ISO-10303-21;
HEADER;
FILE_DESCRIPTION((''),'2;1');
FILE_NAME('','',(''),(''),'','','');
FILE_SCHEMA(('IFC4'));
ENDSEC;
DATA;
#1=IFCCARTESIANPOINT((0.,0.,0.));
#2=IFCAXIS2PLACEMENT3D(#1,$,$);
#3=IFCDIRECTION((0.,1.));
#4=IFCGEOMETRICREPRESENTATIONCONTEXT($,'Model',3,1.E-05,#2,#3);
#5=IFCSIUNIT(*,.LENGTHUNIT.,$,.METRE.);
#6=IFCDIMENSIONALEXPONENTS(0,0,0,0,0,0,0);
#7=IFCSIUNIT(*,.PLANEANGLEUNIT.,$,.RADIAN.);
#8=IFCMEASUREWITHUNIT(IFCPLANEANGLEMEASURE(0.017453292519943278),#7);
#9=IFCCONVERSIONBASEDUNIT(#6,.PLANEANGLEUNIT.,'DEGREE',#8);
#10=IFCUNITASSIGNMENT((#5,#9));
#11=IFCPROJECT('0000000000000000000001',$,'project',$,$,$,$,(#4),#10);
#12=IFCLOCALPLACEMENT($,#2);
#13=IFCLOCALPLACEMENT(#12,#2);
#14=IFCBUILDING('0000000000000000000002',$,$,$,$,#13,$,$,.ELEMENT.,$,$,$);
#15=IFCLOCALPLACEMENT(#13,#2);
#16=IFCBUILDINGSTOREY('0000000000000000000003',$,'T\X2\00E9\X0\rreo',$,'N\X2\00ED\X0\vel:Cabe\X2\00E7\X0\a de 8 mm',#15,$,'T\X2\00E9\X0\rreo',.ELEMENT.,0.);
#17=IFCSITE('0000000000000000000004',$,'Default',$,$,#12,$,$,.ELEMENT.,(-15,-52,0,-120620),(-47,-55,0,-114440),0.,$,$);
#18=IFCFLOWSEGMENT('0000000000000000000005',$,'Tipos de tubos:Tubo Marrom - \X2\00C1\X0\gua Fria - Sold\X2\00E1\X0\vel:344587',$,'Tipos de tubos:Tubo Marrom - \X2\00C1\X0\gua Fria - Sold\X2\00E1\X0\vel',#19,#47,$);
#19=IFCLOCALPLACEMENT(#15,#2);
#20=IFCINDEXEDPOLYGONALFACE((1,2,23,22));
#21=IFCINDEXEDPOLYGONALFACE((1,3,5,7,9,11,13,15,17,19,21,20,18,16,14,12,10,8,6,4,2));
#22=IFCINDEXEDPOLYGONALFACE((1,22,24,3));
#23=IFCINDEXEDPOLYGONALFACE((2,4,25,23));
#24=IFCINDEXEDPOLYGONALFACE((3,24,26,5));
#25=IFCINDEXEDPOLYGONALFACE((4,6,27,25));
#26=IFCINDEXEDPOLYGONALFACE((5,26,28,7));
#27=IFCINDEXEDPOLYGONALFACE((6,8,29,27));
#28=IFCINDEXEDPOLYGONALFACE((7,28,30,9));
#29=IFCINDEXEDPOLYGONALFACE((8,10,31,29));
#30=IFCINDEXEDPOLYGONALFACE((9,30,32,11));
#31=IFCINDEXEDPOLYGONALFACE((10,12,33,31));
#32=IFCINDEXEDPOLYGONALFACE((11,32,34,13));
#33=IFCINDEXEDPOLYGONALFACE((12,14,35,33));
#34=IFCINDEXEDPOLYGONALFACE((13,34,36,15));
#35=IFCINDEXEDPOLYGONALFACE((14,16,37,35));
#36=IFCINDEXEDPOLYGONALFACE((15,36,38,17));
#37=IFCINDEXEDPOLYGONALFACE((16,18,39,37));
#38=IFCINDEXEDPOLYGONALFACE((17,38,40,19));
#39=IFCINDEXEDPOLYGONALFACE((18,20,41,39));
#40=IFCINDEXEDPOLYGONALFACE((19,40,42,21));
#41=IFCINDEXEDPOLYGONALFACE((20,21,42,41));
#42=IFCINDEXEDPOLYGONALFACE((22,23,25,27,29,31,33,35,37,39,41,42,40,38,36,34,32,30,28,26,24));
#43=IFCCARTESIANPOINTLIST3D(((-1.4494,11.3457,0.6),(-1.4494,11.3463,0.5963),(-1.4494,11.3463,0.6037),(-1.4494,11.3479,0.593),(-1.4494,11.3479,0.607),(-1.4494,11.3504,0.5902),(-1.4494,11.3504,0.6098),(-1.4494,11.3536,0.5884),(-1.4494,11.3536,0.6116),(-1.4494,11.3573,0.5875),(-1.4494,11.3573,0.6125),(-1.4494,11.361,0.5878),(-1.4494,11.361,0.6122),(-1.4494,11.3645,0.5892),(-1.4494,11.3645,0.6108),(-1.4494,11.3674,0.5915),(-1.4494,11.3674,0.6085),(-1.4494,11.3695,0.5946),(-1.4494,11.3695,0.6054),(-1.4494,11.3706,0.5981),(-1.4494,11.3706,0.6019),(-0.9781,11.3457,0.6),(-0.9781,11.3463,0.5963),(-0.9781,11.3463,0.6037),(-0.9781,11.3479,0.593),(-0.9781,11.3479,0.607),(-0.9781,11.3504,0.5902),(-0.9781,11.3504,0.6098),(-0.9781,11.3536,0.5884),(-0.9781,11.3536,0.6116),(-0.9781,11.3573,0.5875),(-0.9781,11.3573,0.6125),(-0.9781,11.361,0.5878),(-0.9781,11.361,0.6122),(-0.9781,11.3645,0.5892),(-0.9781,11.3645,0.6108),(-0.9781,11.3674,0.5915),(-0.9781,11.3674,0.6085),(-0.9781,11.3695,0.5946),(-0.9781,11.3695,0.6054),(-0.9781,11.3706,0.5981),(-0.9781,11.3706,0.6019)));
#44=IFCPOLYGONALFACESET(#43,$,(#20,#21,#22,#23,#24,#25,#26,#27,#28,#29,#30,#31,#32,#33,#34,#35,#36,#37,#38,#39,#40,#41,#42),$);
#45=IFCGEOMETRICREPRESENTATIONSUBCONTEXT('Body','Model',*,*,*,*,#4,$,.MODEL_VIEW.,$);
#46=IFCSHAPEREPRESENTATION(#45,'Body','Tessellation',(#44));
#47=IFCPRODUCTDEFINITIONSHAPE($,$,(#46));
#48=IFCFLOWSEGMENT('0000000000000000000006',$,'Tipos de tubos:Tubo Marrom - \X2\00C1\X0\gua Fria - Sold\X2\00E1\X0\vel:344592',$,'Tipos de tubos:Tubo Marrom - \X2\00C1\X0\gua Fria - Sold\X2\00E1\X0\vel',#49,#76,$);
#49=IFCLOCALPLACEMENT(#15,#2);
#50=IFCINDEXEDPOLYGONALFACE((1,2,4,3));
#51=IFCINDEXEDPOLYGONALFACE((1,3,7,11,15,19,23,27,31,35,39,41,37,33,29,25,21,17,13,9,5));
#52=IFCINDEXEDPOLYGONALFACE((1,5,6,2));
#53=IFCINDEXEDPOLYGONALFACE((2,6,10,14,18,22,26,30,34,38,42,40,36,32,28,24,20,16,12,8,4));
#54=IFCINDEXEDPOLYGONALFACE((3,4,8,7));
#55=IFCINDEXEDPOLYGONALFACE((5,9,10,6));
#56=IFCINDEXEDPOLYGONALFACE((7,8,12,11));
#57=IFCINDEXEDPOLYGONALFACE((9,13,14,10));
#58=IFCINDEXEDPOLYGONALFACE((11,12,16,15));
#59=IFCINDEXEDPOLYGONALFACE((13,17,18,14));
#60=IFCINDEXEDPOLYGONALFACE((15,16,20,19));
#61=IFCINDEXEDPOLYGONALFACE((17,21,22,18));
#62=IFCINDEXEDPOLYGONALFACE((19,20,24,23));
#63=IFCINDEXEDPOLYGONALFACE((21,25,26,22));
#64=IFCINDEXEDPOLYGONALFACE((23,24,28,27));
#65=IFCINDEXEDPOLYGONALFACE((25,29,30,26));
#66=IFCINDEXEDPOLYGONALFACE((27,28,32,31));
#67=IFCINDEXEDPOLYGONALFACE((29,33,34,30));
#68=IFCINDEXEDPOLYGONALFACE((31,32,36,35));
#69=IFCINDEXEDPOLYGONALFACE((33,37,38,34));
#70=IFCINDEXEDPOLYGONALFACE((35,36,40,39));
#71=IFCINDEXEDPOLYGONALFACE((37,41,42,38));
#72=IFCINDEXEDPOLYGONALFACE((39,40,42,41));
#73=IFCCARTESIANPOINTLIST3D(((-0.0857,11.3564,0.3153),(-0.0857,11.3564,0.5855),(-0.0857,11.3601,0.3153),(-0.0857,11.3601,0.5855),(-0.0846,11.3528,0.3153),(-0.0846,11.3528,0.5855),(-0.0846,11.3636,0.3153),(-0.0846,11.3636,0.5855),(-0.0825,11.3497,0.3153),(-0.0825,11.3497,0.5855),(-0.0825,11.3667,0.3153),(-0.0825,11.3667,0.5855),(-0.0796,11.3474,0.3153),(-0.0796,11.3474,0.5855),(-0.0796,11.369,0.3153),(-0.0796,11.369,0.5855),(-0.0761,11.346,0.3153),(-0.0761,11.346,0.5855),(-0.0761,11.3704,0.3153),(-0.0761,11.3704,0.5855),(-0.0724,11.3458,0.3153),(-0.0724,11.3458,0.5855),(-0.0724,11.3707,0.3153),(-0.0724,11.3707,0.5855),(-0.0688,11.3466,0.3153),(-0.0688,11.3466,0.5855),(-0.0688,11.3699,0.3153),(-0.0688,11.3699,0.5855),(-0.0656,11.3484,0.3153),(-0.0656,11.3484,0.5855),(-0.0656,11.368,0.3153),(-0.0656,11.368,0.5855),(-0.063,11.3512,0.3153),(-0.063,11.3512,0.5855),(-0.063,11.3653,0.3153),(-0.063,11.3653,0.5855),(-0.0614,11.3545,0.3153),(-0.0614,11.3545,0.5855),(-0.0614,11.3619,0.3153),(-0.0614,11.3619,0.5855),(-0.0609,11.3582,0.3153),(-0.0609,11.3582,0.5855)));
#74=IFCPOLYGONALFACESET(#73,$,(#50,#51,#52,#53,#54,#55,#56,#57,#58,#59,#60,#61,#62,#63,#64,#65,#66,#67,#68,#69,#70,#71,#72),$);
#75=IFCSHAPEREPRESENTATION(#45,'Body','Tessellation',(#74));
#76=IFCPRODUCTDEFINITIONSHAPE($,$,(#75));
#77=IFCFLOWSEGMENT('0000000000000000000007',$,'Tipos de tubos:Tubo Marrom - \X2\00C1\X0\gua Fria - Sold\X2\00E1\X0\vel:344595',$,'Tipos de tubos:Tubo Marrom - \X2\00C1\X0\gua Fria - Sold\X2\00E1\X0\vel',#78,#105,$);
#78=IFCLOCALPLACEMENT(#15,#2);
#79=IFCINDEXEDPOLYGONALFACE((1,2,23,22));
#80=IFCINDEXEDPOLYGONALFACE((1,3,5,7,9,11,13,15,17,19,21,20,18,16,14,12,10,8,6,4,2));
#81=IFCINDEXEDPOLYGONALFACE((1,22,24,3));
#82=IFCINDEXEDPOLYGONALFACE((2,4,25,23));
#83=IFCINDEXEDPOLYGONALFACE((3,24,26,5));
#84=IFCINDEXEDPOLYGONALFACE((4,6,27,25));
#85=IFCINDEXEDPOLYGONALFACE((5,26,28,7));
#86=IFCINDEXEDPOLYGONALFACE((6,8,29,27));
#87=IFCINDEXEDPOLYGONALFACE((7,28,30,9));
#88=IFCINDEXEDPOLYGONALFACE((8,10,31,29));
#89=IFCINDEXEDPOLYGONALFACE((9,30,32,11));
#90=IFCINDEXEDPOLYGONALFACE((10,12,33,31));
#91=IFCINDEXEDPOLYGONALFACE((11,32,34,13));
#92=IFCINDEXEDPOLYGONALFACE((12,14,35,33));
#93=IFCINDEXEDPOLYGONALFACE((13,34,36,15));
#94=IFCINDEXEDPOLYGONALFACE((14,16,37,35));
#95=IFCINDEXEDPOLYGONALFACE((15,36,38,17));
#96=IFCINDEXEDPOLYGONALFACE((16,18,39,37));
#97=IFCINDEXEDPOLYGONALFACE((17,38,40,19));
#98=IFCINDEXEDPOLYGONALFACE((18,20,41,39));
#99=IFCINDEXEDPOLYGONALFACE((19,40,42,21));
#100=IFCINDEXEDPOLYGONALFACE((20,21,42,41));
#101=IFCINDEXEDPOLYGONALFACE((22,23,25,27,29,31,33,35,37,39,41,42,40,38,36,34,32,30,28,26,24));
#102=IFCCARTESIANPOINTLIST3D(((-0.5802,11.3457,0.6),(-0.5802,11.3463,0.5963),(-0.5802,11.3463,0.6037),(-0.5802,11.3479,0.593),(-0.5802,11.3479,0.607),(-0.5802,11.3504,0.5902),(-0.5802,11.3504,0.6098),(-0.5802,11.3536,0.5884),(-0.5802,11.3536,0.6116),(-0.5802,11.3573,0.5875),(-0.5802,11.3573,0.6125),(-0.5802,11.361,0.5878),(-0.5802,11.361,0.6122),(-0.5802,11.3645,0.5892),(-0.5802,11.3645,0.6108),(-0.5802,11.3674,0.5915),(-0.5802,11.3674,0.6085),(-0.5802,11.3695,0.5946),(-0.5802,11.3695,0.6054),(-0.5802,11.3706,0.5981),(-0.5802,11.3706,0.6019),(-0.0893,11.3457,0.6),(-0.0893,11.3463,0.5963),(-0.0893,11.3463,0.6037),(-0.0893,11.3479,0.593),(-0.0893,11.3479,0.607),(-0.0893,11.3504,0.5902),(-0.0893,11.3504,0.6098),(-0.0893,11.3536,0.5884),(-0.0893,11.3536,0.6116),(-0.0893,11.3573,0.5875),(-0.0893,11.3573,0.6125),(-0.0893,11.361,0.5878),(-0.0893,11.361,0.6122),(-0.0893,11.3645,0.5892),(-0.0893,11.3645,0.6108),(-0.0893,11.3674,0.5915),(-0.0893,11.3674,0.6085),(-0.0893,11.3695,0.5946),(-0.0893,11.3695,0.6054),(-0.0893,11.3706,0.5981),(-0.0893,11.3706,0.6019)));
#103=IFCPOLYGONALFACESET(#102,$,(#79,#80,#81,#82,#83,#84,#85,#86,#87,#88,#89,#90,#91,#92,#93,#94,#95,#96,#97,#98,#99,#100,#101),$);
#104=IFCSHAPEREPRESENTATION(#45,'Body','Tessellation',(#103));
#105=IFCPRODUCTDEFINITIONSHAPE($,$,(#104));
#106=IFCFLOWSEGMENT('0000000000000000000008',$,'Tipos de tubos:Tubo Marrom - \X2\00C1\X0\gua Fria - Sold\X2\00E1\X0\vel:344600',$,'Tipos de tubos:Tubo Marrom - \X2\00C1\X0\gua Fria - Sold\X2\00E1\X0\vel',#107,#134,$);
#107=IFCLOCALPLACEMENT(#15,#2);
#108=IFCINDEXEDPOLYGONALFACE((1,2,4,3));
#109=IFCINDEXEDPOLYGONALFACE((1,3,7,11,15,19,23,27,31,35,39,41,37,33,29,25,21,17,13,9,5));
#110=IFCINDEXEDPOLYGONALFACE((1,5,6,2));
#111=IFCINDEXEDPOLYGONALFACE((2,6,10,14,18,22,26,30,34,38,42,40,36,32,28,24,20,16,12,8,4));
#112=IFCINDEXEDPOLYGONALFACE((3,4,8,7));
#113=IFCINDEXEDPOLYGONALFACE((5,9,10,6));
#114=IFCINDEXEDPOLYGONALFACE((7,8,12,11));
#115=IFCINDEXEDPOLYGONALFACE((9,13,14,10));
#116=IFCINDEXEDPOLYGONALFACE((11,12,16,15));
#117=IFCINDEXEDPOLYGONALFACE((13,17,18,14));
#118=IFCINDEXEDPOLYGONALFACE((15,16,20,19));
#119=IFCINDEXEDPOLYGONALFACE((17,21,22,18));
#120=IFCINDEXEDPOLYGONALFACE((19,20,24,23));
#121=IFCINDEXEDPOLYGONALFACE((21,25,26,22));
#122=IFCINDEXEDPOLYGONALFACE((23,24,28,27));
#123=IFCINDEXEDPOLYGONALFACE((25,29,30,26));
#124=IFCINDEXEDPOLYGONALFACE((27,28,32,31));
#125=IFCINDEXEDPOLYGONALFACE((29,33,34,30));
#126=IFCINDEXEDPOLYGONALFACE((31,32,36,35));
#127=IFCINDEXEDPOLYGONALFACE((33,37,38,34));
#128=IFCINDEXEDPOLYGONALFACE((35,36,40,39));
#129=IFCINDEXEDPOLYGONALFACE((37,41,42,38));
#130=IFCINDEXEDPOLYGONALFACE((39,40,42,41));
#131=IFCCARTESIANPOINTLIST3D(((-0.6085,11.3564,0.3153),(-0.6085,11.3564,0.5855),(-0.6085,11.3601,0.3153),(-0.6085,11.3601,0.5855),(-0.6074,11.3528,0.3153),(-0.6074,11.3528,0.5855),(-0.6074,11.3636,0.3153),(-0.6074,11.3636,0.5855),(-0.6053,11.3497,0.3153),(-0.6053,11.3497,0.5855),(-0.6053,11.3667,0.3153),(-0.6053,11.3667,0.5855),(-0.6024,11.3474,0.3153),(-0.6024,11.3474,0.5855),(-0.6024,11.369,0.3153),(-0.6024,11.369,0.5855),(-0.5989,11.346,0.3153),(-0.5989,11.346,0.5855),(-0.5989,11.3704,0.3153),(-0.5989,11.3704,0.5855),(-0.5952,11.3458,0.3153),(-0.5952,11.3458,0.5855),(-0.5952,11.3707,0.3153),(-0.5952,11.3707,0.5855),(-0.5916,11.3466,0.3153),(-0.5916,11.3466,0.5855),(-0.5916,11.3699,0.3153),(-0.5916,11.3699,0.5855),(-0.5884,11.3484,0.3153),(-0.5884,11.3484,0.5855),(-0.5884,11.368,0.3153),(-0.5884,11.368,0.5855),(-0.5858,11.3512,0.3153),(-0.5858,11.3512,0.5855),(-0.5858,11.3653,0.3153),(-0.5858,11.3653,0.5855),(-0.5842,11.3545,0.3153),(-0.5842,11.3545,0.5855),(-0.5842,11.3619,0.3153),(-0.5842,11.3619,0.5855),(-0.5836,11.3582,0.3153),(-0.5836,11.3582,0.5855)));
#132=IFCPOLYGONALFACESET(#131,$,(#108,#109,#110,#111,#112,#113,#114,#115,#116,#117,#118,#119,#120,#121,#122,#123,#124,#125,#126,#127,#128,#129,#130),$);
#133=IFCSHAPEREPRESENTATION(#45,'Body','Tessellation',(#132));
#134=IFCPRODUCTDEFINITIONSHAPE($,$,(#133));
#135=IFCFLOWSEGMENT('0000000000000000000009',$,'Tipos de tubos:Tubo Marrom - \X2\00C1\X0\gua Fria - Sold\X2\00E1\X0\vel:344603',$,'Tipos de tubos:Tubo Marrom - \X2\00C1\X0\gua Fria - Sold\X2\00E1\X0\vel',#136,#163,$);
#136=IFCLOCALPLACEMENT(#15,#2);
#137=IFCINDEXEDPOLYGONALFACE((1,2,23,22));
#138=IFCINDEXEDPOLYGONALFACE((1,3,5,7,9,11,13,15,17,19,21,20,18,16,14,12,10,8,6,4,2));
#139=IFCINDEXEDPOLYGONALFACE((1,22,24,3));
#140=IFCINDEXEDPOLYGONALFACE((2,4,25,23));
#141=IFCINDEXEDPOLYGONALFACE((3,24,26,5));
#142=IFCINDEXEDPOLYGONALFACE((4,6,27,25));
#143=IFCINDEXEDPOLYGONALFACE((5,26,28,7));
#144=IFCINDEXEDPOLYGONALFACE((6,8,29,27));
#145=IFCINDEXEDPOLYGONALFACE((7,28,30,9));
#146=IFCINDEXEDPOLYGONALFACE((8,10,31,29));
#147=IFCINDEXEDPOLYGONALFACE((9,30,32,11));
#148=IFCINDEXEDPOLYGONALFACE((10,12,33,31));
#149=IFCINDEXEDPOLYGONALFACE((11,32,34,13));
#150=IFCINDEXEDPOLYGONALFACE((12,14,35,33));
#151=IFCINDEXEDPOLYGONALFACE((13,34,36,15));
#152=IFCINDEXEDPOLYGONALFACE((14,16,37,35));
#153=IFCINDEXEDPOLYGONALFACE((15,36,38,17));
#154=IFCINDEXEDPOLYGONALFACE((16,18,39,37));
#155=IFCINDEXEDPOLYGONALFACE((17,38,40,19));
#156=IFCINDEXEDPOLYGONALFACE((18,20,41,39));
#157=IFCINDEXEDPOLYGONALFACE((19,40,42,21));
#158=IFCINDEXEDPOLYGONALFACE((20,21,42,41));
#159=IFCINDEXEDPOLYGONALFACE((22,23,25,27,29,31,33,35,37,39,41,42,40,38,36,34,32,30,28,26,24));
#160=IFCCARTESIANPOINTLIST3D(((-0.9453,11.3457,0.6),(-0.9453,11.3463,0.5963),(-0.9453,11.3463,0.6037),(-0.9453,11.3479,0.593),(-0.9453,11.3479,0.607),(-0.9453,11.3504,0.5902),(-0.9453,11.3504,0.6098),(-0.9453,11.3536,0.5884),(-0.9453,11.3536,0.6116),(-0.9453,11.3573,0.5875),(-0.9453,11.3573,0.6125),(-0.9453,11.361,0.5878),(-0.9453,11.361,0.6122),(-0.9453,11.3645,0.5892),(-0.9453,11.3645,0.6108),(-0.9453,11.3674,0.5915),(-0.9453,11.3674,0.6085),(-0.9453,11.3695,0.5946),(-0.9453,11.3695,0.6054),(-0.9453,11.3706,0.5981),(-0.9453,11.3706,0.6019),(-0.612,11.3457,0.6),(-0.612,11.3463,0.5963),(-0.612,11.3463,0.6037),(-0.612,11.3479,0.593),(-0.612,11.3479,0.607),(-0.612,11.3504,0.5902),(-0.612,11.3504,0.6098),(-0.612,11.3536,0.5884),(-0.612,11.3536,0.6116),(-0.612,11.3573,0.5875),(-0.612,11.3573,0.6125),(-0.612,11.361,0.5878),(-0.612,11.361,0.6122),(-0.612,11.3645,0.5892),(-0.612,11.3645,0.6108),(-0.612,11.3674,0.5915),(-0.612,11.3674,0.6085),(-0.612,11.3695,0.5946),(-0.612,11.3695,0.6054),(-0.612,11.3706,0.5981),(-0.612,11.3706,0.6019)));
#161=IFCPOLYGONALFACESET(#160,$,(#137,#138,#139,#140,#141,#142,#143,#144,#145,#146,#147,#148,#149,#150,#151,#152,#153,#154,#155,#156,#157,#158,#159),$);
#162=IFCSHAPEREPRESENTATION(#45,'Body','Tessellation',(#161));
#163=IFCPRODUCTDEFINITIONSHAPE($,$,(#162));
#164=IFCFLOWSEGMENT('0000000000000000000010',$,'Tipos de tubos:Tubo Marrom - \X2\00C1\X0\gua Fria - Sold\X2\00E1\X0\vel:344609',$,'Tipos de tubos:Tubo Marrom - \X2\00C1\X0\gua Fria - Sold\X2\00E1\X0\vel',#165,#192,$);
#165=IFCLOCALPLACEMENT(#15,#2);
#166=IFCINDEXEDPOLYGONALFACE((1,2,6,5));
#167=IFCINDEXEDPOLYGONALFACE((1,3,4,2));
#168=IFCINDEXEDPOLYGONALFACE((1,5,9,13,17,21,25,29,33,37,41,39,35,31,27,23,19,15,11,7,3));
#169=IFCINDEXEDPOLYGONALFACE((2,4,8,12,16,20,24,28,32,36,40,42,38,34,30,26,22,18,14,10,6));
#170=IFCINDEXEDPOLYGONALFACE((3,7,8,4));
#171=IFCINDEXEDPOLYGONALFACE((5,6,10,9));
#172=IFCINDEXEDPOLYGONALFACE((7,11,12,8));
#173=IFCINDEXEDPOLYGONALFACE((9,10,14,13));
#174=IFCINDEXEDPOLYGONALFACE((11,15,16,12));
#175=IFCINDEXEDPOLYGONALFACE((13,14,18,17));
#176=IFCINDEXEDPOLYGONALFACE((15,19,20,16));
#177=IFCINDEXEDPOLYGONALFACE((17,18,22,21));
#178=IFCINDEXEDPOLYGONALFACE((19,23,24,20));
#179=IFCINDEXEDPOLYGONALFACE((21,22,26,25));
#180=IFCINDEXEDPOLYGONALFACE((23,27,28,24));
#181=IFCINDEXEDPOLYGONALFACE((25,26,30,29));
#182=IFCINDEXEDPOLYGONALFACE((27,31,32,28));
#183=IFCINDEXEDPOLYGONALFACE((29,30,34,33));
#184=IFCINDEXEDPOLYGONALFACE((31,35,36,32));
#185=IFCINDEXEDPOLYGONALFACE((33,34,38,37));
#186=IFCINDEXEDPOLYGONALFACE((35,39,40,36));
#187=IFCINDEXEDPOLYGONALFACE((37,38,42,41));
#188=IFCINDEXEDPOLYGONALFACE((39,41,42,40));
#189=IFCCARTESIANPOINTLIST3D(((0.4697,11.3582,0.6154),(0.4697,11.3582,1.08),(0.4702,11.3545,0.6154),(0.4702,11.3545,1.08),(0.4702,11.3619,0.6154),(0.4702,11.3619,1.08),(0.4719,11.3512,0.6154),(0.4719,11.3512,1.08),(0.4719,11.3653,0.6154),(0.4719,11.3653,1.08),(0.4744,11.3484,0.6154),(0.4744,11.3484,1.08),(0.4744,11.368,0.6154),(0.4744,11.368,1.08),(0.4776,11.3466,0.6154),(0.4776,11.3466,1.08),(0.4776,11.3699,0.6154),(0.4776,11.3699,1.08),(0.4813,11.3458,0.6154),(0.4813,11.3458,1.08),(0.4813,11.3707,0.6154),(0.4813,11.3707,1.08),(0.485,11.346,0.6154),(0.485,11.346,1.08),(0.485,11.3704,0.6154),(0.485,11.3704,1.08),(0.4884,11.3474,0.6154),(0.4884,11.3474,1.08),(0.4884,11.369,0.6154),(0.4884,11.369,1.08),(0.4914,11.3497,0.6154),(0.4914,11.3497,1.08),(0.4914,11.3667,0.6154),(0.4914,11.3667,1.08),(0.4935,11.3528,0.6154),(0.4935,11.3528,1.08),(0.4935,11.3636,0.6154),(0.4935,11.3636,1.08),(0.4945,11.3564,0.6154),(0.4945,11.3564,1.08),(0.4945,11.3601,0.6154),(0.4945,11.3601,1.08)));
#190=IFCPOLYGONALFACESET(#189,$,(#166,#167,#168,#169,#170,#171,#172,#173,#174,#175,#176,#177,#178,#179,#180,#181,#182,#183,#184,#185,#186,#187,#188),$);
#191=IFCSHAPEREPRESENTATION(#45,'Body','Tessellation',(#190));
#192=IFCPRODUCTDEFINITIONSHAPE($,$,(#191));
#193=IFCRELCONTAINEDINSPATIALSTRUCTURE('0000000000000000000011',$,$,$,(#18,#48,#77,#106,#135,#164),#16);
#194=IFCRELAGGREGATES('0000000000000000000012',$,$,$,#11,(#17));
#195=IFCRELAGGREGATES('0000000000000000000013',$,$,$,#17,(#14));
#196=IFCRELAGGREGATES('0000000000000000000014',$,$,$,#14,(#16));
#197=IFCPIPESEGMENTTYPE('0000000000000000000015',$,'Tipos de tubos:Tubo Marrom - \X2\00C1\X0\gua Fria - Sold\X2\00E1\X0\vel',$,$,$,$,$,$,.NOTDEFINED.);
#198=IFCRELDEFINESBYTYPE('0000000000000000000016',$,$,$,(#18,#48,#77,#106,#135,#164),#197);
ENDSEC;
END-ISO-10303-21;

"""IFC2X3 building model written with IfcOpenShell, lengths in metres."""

from ifc_helpers import new_model, entity, si_unit, converted_unit, direction, frame, frame_2d, origin, origin_2d_with_axis, place, context, subcontext, project, spatial, circle, extrude, type_object, element, save


model = new_model("IFC2X3")

# Units and contexts
model_context = context("Model", 3, precision=1e-05, world=origin(), true_north=direction((0.0, 1.0)))
body_context = subcontext(model_context, "Body", "Model", "MODEL_VIEW")
ifc_project = project(units=[si_unit("LENGTHUNIT", "METRE"), converted_unit("PLANEANGLEUNIT", "DEGREE", entity("IfcPlaneAngleMeasure", 0.017453292519943278), si_unit("PLANEANGLEUNIT", "RADIAN"), dimensions=[0, 0, 0, 0, 0, 0, 0])], contexts=[model_context])

# Site, building, storey
site_placement = place(None, origin())
site = spatial("IfcSite", under=ifc_project, at=site_placement, Name="Default", CompositionType="ELEMENT", RefLatitude=(-15, -52, 0, -120620), RefLongitude=(-47, -55, 0, -114440), RefElevation=0.0)
building_placement = place(site_placement, origin())
building = spatial("IfcBuilding", under=site, at=building_placement, CompositionType="ELEMENT")
storey_placement = place(building_placement, origin())
storey = spatial("IfcBuildingStorey", under=building, at=storey_placement, Name="Térreo", ObjectType="Nível:Cabeça de 8 mm", LongName="Térreo", CompositionType="ELEMENT", Elevation=0.0)

# Flow segments
pipe_segment_type = type_object("IfcPipeSegmentType", Name="Tipos de tubos:Tubo Marrom - Água Fria - Soldável", PredefinedType="NOTDEFINED")
flow_segment_1_placement = place(storey_placement, origin())
element("IfcFlowSegment", 1, at=flow_segment_1_placement, inside=storey, type_object=pipe_segment_type, Name="Tipos de tubos:Tubo Marrom - Água Fria - Soldável:344587", ObjectType="Tipos de tubos:Tubo Marrom - Água Fria - Soldável", context=body_context, shape_type="SweptSolid", body=[
    extrude(circle(Radius=0.0125, at=origin_2d_with_axis()), frame((-1.4494, 11.3582, 0.6), z_axis=(1.0, 0.0, 0.0), x_axis=(0.0, -1.0, 0.0)), (0.0, 0.0, 1.0), 0.4713),
])
flow_segment_2_placement = place(storey_placement, origin())
element("IfcFlowSegment", 2, at=flow_segment_2_placement, inside=storey, type_object=pipe_segment_type, Name="Tipos de tubos:Tubo Marrom - Água Fria - Soldável:344592", ObjectType="Tipos de tubos:Tubo Marrom - Água Fria - Soldável", context=body_context, shape_type="SweptSolid", body=[
    extrude(circle(Radius=0.0125, at=frame_2d((0.0, 0.0), x_axis=(1.0, 0.0))), frame((-0.0734, 11.3582, 0.3153)), (0.0, 0.0, 1.0), 0.2702),
])
flow_segment_3_placement = place(storey_placement, origin())
element("IfcFlowSegment", 3, at=flow_segment_3_placement, inside=storey, type_object=pipe_segment_type, Name="Tipos de tubos:Tubo Marrom - Água Fria - Soldável:344595", ObjectType="Tipos de tubos:Tubo Marrom - Água Fria - Soldável", context=body_context, shape_type="SweptSolid", body=[
    extrude(circle(Radius=0.0125, at=origin_2d_with_axis()), frame((-0.5802, 11.3582, 0.6), z_axis=(1.0, 0.0, 0.0), x_axis=(0.0, -1.0, 0.0)), (0.0, 0.0, 1.0), 0.491),
])
flow_segment_4_placement = place(storey_placement, origin())
element("IfcFlowSegment", 4, at=flow_segment_4_placement, inside=storey, type_object=pipe_segment_type, Name="Tipos de tubos:Tubo Marrom - Água Fria - Soldável:344600", ObjectType="Tipos de tubos:Tubo Marrom - Água Fria - Soldável", context=body_context, shape_type="SweptSolid", body=[
    extrude(circle(Radius=0.0125, at=origin_2d_with_axis()), frame((-0.5961, 11.3582, 0.3153)), (0.0, 0.0, 1.0), 0.2702),
])
flow_segment_5_placement = place(storey_placement, origin())
element("IfcFlowSegment", 5, at=flow_segment_5_placement, inside=storey, type_object=pipe_segment_type, Name="Tipos de tubos:Tubo Marrom - Água Fria - Soldável:344603", ObjectType="Tipos de tubos:Tubo Marrom - Água Fria - Soldável", context=body_context, shape_type="SweptSolid", body=[
    extrude(circle(Radius=0.0125, at=origin_2d_with_axis()), frame((-0.9453, 11.3582, 0.6), z_axis=(1.0, 0.0, 0.0), x_axis=(0.0, -1.0, 0.0)), (0.0, 0.0, 1.0), 0.3333),
])
flow_segment_6_placement = place(storey_placement, origin())
element("IfcFlowSegment", 6, at=flow_segment_6_placement, inside=storey, type_object=pipe_segment_type, Name="Tipos de tubos:Tubo Marrom - Água Fria - Soldável:344609", ObjectType="Tipos de tubos:Tubo Marrom - Água Fria - Soldável", context=body_context, shape_type="SweptSolid", body=[
    extrude(circle(Radius=0.0125, at=frame_2d((0.0, 0.0), x_axis=(1.0, 0.0))), frame((0.4822, 11.3582, 0.6154), z_axis=(0.0, 0.0, 1.0), x_axis=(-1.0, 0.0, 0.0)), (0.0, 0.0, 1.0), 0.4646),
])

save(model, "model.ifc")
